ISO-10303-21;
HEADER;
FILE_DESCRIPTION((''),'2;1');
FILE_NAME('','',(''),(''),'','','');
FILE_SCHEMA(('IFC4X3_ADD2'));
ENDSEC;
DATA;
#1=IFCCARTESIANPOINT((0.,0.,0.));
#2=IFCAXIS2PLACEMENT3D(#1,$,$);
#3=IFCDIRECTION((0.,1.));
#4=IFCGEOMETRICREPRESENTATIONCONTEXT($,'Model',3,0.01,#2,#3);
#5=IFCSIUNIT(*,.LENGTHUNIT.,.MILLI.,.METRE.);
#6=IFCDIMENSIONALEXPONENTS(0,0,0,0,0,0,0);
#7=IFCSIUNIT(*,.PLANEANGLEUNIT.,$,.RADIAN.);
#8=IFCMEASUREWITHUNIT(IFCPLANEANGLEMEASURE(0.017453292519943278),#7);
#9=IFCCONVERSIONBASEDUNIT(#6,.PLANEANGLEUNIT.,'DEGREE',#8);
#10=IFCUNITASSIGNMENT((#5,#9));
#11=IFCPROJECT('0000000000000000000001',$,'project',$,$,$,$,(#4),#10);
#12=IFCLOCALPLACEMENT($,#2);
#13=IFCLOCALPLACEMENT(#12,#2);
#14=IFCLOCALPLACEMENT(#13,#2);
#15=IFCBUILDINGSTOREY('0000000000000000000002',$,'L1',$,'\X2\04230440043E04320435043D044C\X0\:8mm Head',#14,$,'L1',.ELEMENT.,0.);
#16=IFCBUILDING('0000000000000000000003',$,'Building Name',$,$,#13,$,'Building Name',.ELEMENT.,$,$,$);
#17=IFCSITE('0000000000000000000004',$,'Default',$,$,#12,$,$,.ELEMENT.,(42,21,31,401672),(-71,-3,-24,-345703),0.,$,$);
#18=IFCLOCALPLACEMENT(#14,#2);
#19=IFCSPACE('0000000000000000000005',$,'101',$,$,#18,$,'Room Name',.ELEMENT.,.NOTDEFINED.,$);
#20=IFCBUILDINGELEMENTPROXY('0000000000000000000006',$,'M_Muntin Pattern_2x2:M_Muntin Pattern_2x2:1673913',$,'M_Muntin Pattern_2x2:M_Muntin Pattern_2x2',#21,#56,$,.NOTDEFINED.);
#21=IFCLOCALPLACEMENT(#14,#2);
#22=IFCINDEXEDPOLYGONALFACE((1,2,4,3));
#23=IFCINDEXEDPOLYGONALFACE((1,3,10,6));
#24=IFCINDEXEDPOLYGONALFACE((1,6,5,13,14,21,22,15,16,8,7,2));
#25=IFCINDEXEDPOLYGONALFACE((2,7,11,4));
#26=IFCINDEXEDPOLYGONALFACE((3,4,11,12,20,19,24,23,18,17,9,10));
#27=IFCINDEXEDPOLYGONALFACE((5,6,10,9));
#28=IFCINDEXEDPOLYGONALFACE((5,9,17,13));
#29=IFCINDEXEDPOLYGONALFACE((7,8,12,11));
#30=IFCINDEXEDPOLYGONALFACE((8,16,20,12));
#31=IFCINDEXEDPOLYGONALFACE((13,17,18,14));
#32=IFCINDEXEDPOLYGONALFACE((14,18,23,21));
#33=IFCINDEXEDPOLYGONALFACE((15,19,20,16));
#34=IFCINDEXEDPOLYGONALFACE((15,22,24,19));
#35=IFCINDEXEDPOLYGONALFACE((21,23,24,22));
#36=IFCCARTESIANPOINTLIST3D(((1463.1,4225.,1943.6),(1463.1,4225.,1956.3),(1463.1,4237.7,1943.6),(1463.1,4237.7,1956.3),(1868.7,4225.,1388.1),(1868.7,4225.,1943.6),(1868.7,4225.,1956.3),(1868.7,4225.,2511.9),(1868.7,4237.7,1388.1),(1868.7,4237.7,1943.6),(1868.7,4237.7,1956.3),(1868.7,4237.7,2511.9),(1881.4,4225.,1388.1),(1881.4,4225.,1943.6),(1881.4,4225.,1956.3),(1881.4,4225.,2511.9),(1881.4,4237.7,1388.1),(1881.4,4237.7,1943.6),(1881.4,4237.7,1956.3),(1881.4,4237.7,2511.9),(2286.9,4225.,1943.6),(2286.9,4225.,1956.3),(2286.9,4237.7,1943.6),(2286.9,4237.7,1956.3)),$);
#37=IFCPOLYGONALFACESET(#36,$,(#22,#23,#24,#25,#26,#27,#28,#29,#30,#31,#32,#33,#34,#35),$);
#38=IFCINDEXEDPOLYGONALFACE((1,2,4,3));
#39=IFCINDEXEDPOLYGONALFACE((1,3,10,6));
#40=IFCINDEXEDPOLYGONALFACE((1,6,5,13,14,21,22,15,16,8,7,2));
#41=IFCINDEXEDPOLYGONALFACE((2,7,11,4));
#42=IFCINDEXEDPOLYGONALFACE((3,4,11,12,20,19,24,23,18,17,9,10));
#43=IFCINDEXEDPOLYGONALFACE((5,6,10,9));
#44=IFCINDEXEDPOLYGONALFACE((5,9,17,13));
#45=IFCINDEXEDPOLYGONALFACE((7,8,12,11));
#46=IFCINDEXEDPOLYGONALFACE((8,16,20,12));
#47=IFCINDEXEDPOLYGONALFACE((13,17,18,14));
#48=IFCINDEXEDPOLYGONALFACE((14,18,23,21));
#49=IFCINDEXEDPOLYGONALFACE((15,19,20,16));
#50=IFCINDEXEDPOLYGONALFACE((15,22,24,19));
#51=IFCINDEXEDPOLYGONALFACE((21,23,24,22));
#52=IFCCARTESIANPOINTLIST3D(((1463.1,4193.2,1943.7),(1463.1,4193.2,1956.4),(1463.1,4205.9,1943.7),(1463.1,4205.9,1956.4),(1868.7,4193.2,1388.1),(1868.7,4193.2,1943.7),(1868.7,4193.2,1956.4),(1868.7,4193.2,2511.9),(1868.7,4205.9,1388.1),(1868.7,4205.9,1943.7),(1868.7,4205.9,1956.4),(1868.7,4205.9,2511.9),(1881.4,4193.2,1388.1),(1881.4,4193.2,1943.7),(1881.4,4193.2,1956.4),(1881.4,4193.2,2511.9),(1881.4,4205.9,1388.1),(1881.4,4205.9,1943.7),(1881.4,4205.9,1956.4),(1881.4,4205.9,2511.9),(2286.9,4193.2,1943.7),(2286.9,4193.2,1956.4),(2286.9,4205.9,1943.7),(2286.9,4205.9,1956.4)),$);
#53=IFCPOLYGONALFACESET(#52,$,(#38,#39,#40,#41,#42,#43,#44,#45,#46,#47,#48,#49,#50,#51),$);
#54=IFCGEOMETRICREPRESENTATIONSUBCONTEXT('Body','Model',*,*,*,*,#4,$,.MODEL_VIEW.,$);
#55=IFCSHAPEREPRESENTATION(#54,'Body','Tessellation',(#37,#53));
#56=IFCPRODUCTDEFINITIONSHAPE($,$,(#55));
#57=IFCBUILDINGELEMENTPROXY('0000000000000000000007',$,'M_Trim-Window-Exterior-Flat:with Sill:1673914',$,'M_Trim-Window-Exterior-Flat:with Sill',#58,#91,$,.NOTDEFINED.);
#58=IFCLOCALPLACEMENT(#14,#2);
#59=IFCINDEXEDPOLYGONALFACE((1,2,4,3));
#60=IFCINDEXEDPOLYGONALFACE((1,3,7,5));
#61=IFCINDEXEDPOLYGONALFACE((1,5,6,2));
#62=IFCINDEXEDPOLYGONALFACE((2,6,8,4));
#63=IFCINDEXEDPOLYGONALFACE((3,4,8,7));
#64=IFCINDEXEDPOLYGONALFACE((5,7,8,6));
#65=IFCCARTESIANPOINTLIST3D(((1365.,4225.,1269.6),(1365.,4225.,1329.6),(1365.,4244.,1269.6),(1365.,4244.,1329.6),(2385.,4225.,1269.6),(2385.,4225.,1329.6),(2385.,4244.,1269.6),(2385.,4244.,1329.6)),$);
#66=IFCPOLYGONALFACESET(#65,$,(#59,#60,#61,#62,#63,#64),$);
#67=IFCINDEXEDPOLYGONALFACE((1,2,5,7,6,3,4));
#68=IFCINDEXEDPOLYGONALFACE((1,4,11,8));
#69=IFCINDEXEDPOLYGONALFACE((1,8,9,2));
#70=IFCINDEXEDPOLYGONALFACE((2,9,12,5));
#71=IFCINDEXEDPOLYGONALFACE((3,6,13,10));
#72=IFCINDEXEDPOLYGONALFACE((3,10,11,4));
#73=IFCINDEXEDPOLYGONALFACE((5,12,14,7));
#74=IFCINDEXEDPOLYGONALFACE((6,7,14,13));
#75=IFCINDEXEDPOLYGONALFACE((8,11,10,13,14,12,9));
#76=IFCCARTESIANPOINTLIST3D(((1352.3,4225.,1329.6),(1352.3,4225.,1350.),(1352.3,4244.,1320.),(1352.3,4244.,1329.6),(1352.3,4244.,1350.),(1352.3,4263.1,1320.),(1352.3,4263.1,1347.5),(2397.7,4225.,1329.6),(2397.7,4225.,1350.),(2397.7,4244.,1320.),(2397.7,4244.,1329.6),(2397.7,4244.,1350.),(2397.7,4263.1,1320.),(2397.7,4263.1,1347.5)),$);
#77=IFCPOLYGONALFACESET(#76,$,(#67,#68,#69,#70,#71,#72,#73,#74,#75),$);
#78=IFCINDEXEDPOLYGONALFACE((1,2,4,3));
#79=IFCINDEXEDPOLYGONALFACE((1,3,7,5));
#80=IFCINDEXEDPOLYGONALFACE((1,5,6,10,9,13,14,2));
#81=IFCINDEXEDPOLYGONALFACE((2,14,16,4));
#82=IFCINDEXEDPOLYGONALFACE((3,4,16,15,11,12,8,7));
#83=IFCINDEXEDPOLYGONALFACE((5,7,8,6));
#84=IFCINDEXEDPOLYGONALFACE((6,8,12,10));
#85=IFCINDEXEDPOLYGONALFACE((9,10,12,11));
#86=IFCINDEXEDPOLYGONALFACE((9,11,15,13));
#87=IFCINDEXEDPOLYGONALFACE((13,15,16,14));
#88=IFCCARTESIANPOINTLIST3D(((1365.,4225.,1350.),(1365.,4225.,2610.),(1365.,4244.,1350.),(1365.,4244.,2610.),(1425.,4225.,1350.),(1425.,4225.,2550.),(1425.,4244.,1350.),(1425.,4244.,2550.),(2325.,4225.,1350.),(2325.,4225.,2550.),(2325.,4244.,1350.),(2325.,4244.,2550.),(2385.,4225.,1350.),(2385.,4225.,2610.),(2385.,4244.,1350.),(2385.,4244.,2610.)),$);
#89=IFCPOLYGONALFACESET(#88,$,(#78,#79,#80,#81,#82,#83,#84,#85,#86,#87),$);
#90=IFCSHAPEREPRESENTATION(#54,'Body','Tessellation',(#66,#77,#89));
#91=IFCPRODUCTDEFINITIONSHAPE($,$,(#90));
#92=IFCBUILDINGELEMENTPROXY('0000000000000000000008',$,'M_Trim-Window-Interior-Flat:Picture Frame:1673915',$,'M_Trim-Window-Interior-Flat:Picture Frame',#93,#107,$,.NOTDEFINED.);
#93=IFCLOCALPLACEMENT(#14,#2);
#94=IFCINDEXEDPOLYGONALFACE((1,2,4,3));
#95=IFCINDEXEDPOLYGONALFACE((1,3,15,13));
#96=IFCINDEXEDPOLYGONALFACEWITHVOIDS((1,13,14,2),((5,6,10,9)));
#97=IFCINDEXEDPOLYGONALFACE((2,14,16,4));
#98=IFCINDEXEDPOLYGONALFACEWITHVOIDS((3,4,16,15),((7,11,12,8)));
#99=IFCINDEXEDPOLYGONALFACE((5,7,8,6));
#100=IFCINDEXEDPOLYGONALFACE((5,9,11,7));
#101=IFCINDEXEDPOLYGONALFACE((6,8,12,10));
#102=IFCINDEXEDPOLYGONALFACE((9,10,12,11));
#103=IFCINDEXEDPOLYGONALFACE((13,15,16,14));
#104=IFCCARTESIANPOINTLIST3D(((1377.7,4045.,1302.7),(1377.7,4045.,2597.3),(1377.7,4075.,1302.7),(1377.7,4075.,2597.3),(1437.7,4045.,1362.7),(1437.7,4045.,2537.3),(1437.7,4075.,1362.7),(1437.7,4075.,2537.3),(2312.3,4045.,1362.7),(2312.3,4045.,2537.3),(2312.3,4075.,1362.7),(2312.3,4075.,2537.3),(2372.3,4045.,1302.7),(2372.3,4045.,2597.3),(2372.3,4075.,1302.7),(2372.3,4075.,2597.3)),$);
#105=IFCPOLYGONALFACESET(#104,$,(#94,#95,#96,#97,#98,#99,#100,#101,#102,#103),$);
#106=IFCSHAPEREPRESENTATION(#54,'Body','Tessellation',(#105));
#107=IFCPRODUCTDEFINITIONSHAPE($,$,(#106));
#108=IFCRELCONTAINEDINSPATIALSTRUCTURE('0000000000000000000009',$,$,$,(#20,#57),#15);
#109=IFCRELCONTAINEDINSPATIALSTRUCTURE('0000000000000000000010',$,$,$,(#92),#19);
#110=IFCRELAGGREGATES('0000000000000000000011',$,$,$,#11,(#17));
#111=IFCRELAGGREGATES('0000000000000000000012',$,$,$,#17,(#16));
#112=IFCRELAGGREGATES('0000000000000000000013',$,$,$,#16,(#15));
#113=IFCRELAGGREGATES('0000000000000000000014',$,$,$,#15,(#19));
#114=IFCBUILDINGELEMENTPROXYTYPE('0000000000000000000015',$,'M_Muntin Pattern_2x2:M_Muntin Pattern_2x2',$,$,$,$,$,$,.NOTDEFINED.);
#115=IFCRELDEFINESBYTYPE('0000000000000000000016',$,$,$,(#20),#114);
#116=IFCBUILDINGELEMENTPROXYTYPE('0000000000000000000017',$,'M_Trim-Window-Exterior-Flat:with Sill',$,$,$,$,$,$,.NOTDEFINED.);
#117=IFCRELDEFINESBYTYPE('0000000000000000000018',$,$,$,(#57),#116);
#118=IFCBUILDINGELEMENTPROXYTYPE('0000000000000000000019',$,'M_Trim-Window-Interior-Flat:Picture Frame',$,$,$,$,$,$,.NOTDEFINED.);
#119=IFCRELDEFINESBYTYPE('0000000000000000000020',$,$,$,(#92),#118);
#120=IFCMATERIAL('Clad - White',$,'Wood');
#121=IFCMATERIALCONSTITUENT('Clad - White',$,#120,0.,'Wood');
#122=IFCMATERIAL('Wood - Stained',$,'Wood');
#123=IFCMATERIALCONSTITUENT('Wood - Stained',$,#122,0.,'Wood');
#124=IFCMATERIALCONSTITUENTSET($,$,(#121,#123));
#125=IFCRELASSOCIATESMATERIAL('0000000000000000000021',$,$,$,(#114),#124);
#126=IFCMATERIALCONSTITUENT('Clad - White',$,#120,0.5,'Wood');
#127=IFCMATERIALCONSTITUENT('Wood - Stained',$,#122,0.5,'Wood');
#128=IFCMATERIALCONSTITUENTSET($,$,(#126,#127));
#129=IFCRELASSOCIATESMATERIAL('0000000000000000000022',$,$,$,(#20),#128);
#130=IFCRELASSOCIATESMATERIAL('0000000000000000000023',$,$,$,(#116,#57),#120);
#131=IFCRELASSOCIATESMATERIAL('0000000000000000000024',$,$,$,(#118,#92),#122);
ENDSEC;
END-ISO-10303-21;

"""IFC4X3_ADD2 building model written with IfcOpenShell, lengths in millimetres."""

from ifc_helpers import new_model, entity, si_unit, converted_unit, direction, frame, frame_2d, origin, place, context, subcontext, project, spatial, polyline, rectangle, outline, extrude, source, transform, mapped, material, constituent, constituent_set, type_object, type_shapes, element, save


model = new_model("IFC4X3_ADD2")

# Units and contexts
model_context = context("Model", 3, precision=0.01, world=origin(), true_north=direction((0.0, 1.0)))
body_context = subcontext(model_context, "Body", "Model", "MODEL_VIEW")
ifc_project = project(units=[si_unit("LENGTHUNIT", "METRE", prefix="MILLI"), converted_unit("PLANEANGLEUNIT", "DEGREE", entity("IfcPlaneAngleMeasure", 0.017453292519943278), si_unit("PLANEANGLEUNIT", "RADIAN"), dimensions=[0, 0, 0, 0, 0, 0, 0])], contexts=[model_context])

# Site, building, storey
site_placement = place(None, origin())
site = spatial("IfcSite", under=ifc_project, at=site_placement, Name="Default", CompositionType="ELEMENT", RefLatitude=(42, 21, 31, 401672), RefLongitude=(-71, -3, -24, -345703), RefElevation=0.0)
building_placement = place(site_placement, origin())
building = spatial("IfcBuilding", under=site, at=building_placement, Name="Building Name", LongName="Building Name", CompositionType="ELEMENT")
storey_placement = place(building_placement, origin())
storey = spatial("IfcBuildingStorey", under=building, at=storey_placement, Name="L1", ObjectType="Уровень:8mm Head", LongName="L1", CompositionType="ELEMENT", Elevation=0.0)

# Building element proxies
ifc_material_1 = material(Name="Clad - White", Category="Wood")
ifc_constituent_1 = constituent(ifc_material_1, Name="Clad - White", Category="Wood", fraction=0.5)
ifc_material_2 = material(Name="Wood - Stained", Category="Wood")
ifc_constituent_2 = constituent(ifc_material_2, Name="Wood - Stained", Category="Wood", fraction=0.5)
ifc_constituent_set_1 = constituent_set(constituents=[ifc_constituent_1, ifc_constituent_2])
ifc_constituent_3 = constituent(ifc_material_1, Name="Clad - White", Category="Wood", fraction=0.0)
ifc_constituent_4 = constituent(ifc_material_2, Name="Wood - Stained", Category="Wood", fraction=0.0)
ifc_constituent_set_2 = constituent_set(constituents=[ifc_constituent_3, ifc_constituent_4])
building_element_proxy_type_1 = type_object("IfcBuildingElementProxyType", Name="M_Muntin Pattern_2x2:M_Muntin Pattern_2x2", PredefinedType="NOTDEFINED", material=ifc_constituent_set_2)
shared_shape_1 = source(origin(), body_context, "Body", "SweptSolid", [
    extrude(outline(polyline([(6.4, -6.4), (561.9, -6.4), (561.9, 6.3), (6.4, 6.3), (6.4, 411.9), (-6.3, 411.9), (-6.3, 6.3), (-561.9, 6.3), (-561.9, -6.4), (-6.3, -6.4), (-6.3, -411.9), (6.4, -411.9), (6.4, -6.4)])), frame((0.0, -22.2, 561.9), z_axis=(0.0, 1.0, 0.0), x_axis=(0.0, 0.0, 1.0)), (0.0, 0.0, 1.0), 12.7),
    extrude(outline(polyline([(6.4, -6.4), (561.9, -6.4), (561.9, 6.3), (6.4, 6.3), (6.4, 411.9), (-6.3, 411.9), (-6.3, 6.3), (-561.9, 6.3), (-561.9, -6.4), (-6.3, -6.4), (-6.3, -411.9), (6.4, -411.9), (6.4, -6.4)])), frame((0.0, 9.5, 561.9), z_axis=(0.0, 1.0, 0.0), x_axis=(0.0, 0.0, 1.0)), (0.0, 0.0, 1.0), 12.7),
])
type_shapes(building_element_proxy_type_1, [shared_shape_1])
proxy_1_placement = place(storey_placement, frame((1875.0, 4215.5, 1388.1), z_axis=(0.0, 0.0, 1.0), x_axis=(-1.0, 0.0, 0.0)))
element("IfcBuildingElementProxy", 1, at=proxy_1_placement, inside=storey, type_object=building_element_proxy_type_1, material=ifc_constituent_set_1, Name="M_Muntin Pattern_2x2:M_Muntin Pattern_2x2:1673913", ObjectType="M_Muntin Pattern_2x2:M_Muntin Pattern_2x2", PredefinedType="NOTDEFINED", context=body_context, shape_type="MappedRepresentation", body=[
    mapped(shared_shape_1, transform((0.0, 0.0, 0.0), scale=1.0)),
])
building_element_proxy_type_2 = type_object("IfcBuildingElementProxyType", Name="M_Trim-Window-Exterior-Flat:with Sill", PredefinedType="NOTDEFINED", material=ifc_material_1)
shared_shape_2 = source(origin(), body_context, "Body", "SweptSolid", [
    extrude(rectangle(XDim=1020.0, YDim=60.0, at=frame_2d((0.0, 0.0), x_axis=(1.0, 0.0))), frame((0.0, -1250.4, 0.0), z_axis=(0.0, 0.0, 1.0), x_axis=(-1.0, 0.0, 0.0)), (0.0, 0.0, 1.0), 19.0),
    extrude(outline(polyline([(-19.0, -15.2), (0.0, -15.2), (0.0, -5.7), (19.0, -5.7), (19.0, 14.8), (0.0, 14.8), (-19.0, 12.3), (-19.0, -15.2)])), frame((-522.7, -1214.8, 19.0), z_axis=(1.0, 0.0, 0.0), x_axis=(0.0, 0.0, -1.0)), (0.0, 0.0, 1.0), 1045.4),
    extrude(outline(polyline([(-645.0, -510.0), (615.0, -510.0), (615.0, -450.0), (-585.0, -450.0), (-585.0, 450.0), (615.0, 450.0), (615.0, 510.0), (-645.0, 510.0), (-645.0, -510.0)])), frame((0.0, -585.0, 0.0), z_axis=(0.0, 0.0, 1.0), x_axis=(0.0, -1.0, 0.0)), (0.0, 0.0, 1.0), 19.0),
])
type_shapes(building_element_proxy_type_2, [shared_shape_2])
proxy_2_placement = place(storey_placement, frame((1875.0, 4225.0, 2550.0), z_axis=(0.0, 1.0, 0.0), x_axis=(-1.0, 0.0, 0.0)))
element("IfcBuildingElementProxy", 2, at=proxy_2_placement, inside=storey, type_object=building_element_proxy_type_2, material=ifc_material_1, Name="M_Trim-Window-Exterior-Flat:with Sill:1673914", ObjectType="M_Trim-Window-Exterior-Flat:with Sill", PredefinedType="NOTDEFINED", context=body_context, shape_type="MappedRepresentation", body=[
    mapped(shared_shape_2, transform((0.0, 0.0, 0.0), scale=1.0)),
])

# Shared definitions
space_placement = place(storey_placement, origin())
space = spatial("IfcSpace", under=storey, at=space_placement, Name="101", LongName="Room Name", CompositionType="ELEMENT", PredefinedType="NOTDEFINED")

# Building element proxy
building_element_proxy_type_3 = type_object("IfcBuildingElementProxyType", Name="M_Trim-Window-Interior-Flat:Picture Frame", PredefinedType="NOTDEFINED", material=ifc_material_2)
shared_shape_3 = source(origin(), body_context, "Body", "SweptSolid", [
    extrude(outline(polyline([(-497.3, -647.3), (497.3, -647.3), (497.3, 647.3), (-497.3, 647.3), (-497.3, -647.3)]), holes=[polyline([(-437.3, -587.3), (-437.3, 587.3), (437.3, 587.3), (437.3, -587.3), (-437.3, -587.3)])]), frame((0.0, -600.0, 0.0), z_axis=(0.0, 0.0, 1.0), x_axis=(-1.0, 0.0, 0.0)), (0.0, 0.0, 1.0), 30.0),
])
type_shapes(building_element_proxy_type_3, [shared_shape_3])
proxy_3_placement = place(space_placement, frame((1875.0, 4075.0, 2550.0), z_axis=(0.0, -1.0, 0.0), x_axis=(1.0, 0.0, 0.0)))
element("IfcBuildingElementProxy", 3, at=proxy_3_placement, inside=space, type_object=building_element_proxy_type_3, material=ifc_material_2, Name="M_Trim-Window-Interior-Flat:Picture Frame:1673915", ObjectType="M_Trim-Window-Interior-Flat:Picture Frame", PredefinedType="NOTDEFINED", context=body_context, shape_type="MappedRepresentation", body=[
    mapped(shared_shape_3, transform((0.0, 0.0, 0.0), scale=1.0)),
])

save(model, "model.ifc")
